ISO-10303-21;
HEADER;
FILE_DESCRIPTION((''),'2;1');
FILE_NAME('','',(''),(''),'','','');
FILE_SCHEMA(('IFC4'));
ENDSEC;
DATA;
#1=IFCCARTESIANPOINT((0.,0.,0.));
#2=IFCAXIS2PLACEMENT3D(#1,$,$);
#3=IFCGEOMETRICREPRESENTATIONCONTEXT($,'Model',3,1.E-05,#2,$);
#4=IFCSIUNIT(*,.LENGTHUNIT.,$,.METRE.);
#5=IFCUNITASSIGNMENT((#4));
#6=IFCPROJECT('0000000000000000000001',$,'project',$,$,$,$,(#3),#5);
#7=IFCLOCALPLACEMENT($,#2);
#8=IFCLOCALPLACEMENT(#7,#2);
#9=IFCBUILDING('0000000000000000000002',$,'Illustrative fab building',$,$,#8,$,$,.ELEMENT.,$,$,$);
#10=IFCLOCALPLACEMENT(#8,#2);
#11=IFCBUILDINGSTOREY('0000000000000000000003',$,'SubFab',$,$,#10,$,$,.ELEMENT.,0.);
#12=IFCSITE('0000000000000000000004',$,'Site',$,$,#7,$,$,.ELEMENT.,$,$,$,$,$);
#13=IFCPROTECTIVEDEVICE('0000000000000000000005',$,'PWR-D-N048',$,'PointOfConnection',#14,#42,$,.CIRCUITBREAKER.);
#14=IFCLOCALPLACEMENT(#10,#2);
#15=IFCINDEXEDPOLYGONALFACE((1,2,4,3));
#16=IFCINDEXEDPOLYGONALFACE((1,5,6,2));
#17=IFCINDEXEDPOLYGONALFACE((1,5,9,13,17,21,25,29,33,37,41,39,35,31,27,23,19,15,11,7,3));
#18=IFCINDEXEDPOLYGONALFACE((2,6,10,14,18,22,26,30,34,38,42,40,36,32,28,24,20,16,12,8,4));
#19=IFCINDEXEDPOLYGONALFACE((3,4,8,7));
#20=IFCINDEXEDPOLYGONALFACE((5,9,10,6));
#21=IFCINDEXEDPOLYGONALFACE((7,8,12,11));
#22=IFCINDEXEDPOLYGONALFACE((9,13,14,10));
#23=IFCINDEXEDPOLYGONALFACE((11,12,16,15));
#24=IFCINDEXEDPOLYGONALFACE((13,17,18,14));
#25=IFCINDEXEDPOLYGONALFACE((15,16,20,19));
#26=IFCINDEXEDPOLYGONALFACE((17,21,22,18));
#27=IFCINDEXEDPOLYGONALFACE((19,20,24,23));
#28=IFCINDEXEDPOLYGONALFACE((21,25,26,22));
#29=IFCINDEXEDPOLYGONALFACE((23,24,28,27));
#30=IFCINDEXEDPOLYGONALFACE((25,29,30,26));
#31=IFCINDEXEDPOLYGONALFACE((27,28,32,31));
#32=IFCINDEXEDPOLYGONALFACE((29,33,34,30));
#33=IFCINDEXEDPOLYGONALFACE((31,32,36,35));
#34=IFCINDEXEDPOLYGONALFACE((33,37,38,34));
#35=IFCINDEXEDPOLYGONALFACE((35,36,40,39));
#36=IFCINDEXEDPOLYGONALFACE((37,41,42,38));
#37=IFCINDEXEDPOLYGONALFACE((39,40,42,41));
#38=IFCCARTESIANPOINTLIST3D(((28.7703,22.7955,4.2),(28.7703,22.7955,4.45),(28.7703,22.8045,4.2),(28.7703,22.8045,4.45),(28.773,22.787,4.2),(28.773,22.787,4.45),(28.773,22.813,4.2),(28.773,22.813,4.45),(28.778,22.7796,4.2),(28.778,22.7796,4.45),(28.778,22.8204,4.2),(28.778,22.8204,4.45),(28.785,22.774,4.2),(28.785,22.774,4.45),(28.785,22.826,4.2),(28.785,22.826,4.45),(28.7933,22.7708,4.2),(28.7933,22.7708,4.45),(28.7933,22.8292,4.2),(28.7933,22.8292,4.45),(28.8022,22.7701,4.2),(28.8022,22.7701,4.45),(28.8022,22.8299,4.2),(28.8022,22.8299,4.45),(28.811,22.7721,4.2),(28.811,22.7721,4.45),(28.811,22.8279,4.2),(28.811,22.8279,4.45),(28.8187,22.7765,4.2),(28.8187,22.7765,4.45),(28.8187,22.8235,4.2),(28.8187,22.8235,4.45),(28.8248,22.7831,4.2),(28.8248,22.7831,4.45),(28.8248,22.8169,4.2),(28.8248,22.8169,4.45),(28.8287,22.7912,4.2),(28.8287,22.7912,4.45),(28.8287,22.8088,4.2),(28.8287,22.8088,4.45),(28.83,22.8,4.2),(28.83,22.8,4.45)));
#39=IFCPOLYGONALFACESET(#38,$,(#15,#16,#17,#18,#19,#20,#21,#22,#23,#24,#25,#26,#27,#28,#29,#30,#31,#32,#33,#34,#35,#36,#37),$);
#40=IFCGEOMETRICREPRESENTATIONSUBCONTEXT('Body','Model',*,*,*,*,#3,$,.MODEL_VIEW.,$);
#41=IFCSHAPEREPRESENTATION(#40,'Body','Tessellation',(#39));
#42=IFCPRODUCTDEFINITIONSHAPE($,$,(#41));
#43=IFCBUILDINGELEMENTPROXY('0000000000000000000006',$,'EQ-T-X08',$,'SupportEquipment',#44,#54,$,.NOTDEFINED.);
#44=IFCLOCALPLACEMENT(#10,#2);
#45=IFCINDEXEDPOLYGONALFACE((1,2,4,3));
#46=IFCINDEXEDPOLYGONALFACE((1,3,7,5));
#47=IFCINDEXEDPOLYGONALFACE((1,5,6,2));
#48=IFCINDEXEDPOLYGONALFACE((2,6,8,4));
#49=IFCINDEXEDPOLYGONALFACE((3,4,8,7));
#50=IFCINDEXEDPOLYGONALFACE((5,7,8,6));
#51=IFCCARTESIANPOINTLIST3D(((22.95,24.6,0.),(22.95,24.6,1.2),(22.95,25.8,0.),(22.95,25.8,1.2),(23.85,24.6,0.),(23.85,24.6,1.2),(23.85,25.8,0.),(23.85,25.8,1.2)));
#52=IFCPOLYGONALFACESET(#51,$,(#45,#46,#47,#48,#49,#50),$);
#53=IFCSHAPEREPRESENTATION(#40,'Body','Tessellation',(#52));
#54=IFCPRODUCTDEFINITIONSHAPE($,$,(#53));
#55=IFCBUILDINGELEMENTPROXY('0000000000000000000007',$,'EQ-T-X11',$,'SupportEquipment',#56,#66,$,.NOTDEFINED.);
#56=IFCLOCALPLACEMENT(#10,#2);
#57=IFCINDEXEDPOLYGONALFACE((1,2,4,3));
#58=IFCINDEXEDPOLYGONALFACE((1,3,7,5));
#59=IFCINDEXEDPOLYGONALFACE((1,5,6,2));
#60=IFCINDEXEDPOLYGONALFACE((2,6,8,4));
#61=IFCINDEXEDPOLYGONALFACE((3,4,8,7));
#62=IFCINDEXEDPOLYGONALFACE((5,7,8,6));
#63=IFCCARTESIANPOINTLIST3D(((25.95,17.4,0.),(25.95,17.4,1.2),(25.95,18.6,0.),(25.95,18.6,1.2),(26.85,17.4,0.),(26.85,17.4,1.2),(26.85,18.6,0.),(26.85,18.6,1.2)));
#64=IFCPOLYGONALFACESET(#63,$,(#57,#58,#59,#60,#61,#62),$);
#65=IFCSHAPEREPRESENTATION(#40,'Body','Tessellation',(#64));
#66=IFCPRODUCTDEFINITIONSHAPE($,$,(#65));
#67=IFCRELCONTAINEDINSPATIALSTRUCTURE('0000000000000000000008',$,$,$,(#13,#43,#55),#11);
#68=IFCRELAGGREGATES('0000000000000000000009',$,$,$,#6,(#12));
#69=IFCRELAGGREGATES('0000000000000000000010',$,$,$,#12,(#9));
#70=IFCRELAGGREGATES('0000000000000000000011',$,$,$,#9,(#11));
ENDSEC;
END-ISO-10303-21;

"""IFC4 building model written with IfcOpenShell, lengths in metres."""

from ifc_helpers import new_model, entity, si_unit, frame, origin, origin_2d, place, context, subcontext, project, spatial, rectangle, extrude, element, save


model = new_model("IFC4")

# Units and contexts
model_context = context("Model", 3, precision=1e-05, world=origin())
body_context = subcontext(model_context, "Body", "Model", "MODEL_VIEW")
ifc_project = project(units=[si_unit("LENGTHUNIT", "METRE")], contexts=[model_context])

# Site, building, storey
site_placement = place(None, origin())
site = spatial("IfcSite", under=ifc_project, at=site_placement, Name="Site", CompositionType="ELEMENT")
building_placement = place(site_placement, origin())
building = spatial("IfcBuilding", under=site, at=building_placement, Name="Illustrative fab building", CompositionType="ELEMENT")
storey_placement = place(building_placement, origin())
storey = spatial("IfcBuildingStorey", under=building, at=storey_placement, Name="SubFab", CompositionType="ELEMENT", Elevation=0.0)

# Protective device
protective_device_placement = place(storey_placement, frame((28.8, 22.8, 4.2)))
element("IfcProtectiveDevice", 1, at=protective_device_placement, inside=storey, Name="PWR-D-N048", ObjectType="PointOfConnection", PredefinedType="CIRCUITBREAKER", context=body_context, shape_type="AdvancedSweptSolid", body=[
    entity("IfcSweptDiskSolid", entity("IfcPolyline", [entity("IfcCartesianPoint", [0.0, 0.0, 0.0]), entity("IfcCartesianPoint", [0.0, 0.0, 0.25])]), 0.03),
])

# Building element proxies
proxy_1_placement = place(storey_placement, frame((23.4, 25.2, 0.0)))
element("IfcBuildingElementProxy", 2, at=proxy_1_placement, inside=storey, Name="EQ-T-X08", ObjectType="SupportEquipment", PredefinedType="NOTDEFINED", context=body_context, shape_type="SweptSolid", body=[
    extrude(rectangle(XDim=0.9, YDim=1.2, at=origin_2d()), origin(), (0.0, 0.0, 1.0), 1.2),
])
proxy_2_placement = place(storey_placement, frame((26.4, 18.0, 0.0)))
element("IfcBuildingElementProxy", 3, at=proxy_2_placement, inside=storey, Name="EQ-T-X11", ObjectType="SupportEquipment", PredefinedType="NOTDEFINED", context=body_context, shape_type="SweptSolid", body=[
    extrude(rectangle(XDim=0.9, YDim=1.2, at=origin_2d()), origin(), (0.0, 0.0, 1.0), 1.2),
])

save(model, "model.ifc")
